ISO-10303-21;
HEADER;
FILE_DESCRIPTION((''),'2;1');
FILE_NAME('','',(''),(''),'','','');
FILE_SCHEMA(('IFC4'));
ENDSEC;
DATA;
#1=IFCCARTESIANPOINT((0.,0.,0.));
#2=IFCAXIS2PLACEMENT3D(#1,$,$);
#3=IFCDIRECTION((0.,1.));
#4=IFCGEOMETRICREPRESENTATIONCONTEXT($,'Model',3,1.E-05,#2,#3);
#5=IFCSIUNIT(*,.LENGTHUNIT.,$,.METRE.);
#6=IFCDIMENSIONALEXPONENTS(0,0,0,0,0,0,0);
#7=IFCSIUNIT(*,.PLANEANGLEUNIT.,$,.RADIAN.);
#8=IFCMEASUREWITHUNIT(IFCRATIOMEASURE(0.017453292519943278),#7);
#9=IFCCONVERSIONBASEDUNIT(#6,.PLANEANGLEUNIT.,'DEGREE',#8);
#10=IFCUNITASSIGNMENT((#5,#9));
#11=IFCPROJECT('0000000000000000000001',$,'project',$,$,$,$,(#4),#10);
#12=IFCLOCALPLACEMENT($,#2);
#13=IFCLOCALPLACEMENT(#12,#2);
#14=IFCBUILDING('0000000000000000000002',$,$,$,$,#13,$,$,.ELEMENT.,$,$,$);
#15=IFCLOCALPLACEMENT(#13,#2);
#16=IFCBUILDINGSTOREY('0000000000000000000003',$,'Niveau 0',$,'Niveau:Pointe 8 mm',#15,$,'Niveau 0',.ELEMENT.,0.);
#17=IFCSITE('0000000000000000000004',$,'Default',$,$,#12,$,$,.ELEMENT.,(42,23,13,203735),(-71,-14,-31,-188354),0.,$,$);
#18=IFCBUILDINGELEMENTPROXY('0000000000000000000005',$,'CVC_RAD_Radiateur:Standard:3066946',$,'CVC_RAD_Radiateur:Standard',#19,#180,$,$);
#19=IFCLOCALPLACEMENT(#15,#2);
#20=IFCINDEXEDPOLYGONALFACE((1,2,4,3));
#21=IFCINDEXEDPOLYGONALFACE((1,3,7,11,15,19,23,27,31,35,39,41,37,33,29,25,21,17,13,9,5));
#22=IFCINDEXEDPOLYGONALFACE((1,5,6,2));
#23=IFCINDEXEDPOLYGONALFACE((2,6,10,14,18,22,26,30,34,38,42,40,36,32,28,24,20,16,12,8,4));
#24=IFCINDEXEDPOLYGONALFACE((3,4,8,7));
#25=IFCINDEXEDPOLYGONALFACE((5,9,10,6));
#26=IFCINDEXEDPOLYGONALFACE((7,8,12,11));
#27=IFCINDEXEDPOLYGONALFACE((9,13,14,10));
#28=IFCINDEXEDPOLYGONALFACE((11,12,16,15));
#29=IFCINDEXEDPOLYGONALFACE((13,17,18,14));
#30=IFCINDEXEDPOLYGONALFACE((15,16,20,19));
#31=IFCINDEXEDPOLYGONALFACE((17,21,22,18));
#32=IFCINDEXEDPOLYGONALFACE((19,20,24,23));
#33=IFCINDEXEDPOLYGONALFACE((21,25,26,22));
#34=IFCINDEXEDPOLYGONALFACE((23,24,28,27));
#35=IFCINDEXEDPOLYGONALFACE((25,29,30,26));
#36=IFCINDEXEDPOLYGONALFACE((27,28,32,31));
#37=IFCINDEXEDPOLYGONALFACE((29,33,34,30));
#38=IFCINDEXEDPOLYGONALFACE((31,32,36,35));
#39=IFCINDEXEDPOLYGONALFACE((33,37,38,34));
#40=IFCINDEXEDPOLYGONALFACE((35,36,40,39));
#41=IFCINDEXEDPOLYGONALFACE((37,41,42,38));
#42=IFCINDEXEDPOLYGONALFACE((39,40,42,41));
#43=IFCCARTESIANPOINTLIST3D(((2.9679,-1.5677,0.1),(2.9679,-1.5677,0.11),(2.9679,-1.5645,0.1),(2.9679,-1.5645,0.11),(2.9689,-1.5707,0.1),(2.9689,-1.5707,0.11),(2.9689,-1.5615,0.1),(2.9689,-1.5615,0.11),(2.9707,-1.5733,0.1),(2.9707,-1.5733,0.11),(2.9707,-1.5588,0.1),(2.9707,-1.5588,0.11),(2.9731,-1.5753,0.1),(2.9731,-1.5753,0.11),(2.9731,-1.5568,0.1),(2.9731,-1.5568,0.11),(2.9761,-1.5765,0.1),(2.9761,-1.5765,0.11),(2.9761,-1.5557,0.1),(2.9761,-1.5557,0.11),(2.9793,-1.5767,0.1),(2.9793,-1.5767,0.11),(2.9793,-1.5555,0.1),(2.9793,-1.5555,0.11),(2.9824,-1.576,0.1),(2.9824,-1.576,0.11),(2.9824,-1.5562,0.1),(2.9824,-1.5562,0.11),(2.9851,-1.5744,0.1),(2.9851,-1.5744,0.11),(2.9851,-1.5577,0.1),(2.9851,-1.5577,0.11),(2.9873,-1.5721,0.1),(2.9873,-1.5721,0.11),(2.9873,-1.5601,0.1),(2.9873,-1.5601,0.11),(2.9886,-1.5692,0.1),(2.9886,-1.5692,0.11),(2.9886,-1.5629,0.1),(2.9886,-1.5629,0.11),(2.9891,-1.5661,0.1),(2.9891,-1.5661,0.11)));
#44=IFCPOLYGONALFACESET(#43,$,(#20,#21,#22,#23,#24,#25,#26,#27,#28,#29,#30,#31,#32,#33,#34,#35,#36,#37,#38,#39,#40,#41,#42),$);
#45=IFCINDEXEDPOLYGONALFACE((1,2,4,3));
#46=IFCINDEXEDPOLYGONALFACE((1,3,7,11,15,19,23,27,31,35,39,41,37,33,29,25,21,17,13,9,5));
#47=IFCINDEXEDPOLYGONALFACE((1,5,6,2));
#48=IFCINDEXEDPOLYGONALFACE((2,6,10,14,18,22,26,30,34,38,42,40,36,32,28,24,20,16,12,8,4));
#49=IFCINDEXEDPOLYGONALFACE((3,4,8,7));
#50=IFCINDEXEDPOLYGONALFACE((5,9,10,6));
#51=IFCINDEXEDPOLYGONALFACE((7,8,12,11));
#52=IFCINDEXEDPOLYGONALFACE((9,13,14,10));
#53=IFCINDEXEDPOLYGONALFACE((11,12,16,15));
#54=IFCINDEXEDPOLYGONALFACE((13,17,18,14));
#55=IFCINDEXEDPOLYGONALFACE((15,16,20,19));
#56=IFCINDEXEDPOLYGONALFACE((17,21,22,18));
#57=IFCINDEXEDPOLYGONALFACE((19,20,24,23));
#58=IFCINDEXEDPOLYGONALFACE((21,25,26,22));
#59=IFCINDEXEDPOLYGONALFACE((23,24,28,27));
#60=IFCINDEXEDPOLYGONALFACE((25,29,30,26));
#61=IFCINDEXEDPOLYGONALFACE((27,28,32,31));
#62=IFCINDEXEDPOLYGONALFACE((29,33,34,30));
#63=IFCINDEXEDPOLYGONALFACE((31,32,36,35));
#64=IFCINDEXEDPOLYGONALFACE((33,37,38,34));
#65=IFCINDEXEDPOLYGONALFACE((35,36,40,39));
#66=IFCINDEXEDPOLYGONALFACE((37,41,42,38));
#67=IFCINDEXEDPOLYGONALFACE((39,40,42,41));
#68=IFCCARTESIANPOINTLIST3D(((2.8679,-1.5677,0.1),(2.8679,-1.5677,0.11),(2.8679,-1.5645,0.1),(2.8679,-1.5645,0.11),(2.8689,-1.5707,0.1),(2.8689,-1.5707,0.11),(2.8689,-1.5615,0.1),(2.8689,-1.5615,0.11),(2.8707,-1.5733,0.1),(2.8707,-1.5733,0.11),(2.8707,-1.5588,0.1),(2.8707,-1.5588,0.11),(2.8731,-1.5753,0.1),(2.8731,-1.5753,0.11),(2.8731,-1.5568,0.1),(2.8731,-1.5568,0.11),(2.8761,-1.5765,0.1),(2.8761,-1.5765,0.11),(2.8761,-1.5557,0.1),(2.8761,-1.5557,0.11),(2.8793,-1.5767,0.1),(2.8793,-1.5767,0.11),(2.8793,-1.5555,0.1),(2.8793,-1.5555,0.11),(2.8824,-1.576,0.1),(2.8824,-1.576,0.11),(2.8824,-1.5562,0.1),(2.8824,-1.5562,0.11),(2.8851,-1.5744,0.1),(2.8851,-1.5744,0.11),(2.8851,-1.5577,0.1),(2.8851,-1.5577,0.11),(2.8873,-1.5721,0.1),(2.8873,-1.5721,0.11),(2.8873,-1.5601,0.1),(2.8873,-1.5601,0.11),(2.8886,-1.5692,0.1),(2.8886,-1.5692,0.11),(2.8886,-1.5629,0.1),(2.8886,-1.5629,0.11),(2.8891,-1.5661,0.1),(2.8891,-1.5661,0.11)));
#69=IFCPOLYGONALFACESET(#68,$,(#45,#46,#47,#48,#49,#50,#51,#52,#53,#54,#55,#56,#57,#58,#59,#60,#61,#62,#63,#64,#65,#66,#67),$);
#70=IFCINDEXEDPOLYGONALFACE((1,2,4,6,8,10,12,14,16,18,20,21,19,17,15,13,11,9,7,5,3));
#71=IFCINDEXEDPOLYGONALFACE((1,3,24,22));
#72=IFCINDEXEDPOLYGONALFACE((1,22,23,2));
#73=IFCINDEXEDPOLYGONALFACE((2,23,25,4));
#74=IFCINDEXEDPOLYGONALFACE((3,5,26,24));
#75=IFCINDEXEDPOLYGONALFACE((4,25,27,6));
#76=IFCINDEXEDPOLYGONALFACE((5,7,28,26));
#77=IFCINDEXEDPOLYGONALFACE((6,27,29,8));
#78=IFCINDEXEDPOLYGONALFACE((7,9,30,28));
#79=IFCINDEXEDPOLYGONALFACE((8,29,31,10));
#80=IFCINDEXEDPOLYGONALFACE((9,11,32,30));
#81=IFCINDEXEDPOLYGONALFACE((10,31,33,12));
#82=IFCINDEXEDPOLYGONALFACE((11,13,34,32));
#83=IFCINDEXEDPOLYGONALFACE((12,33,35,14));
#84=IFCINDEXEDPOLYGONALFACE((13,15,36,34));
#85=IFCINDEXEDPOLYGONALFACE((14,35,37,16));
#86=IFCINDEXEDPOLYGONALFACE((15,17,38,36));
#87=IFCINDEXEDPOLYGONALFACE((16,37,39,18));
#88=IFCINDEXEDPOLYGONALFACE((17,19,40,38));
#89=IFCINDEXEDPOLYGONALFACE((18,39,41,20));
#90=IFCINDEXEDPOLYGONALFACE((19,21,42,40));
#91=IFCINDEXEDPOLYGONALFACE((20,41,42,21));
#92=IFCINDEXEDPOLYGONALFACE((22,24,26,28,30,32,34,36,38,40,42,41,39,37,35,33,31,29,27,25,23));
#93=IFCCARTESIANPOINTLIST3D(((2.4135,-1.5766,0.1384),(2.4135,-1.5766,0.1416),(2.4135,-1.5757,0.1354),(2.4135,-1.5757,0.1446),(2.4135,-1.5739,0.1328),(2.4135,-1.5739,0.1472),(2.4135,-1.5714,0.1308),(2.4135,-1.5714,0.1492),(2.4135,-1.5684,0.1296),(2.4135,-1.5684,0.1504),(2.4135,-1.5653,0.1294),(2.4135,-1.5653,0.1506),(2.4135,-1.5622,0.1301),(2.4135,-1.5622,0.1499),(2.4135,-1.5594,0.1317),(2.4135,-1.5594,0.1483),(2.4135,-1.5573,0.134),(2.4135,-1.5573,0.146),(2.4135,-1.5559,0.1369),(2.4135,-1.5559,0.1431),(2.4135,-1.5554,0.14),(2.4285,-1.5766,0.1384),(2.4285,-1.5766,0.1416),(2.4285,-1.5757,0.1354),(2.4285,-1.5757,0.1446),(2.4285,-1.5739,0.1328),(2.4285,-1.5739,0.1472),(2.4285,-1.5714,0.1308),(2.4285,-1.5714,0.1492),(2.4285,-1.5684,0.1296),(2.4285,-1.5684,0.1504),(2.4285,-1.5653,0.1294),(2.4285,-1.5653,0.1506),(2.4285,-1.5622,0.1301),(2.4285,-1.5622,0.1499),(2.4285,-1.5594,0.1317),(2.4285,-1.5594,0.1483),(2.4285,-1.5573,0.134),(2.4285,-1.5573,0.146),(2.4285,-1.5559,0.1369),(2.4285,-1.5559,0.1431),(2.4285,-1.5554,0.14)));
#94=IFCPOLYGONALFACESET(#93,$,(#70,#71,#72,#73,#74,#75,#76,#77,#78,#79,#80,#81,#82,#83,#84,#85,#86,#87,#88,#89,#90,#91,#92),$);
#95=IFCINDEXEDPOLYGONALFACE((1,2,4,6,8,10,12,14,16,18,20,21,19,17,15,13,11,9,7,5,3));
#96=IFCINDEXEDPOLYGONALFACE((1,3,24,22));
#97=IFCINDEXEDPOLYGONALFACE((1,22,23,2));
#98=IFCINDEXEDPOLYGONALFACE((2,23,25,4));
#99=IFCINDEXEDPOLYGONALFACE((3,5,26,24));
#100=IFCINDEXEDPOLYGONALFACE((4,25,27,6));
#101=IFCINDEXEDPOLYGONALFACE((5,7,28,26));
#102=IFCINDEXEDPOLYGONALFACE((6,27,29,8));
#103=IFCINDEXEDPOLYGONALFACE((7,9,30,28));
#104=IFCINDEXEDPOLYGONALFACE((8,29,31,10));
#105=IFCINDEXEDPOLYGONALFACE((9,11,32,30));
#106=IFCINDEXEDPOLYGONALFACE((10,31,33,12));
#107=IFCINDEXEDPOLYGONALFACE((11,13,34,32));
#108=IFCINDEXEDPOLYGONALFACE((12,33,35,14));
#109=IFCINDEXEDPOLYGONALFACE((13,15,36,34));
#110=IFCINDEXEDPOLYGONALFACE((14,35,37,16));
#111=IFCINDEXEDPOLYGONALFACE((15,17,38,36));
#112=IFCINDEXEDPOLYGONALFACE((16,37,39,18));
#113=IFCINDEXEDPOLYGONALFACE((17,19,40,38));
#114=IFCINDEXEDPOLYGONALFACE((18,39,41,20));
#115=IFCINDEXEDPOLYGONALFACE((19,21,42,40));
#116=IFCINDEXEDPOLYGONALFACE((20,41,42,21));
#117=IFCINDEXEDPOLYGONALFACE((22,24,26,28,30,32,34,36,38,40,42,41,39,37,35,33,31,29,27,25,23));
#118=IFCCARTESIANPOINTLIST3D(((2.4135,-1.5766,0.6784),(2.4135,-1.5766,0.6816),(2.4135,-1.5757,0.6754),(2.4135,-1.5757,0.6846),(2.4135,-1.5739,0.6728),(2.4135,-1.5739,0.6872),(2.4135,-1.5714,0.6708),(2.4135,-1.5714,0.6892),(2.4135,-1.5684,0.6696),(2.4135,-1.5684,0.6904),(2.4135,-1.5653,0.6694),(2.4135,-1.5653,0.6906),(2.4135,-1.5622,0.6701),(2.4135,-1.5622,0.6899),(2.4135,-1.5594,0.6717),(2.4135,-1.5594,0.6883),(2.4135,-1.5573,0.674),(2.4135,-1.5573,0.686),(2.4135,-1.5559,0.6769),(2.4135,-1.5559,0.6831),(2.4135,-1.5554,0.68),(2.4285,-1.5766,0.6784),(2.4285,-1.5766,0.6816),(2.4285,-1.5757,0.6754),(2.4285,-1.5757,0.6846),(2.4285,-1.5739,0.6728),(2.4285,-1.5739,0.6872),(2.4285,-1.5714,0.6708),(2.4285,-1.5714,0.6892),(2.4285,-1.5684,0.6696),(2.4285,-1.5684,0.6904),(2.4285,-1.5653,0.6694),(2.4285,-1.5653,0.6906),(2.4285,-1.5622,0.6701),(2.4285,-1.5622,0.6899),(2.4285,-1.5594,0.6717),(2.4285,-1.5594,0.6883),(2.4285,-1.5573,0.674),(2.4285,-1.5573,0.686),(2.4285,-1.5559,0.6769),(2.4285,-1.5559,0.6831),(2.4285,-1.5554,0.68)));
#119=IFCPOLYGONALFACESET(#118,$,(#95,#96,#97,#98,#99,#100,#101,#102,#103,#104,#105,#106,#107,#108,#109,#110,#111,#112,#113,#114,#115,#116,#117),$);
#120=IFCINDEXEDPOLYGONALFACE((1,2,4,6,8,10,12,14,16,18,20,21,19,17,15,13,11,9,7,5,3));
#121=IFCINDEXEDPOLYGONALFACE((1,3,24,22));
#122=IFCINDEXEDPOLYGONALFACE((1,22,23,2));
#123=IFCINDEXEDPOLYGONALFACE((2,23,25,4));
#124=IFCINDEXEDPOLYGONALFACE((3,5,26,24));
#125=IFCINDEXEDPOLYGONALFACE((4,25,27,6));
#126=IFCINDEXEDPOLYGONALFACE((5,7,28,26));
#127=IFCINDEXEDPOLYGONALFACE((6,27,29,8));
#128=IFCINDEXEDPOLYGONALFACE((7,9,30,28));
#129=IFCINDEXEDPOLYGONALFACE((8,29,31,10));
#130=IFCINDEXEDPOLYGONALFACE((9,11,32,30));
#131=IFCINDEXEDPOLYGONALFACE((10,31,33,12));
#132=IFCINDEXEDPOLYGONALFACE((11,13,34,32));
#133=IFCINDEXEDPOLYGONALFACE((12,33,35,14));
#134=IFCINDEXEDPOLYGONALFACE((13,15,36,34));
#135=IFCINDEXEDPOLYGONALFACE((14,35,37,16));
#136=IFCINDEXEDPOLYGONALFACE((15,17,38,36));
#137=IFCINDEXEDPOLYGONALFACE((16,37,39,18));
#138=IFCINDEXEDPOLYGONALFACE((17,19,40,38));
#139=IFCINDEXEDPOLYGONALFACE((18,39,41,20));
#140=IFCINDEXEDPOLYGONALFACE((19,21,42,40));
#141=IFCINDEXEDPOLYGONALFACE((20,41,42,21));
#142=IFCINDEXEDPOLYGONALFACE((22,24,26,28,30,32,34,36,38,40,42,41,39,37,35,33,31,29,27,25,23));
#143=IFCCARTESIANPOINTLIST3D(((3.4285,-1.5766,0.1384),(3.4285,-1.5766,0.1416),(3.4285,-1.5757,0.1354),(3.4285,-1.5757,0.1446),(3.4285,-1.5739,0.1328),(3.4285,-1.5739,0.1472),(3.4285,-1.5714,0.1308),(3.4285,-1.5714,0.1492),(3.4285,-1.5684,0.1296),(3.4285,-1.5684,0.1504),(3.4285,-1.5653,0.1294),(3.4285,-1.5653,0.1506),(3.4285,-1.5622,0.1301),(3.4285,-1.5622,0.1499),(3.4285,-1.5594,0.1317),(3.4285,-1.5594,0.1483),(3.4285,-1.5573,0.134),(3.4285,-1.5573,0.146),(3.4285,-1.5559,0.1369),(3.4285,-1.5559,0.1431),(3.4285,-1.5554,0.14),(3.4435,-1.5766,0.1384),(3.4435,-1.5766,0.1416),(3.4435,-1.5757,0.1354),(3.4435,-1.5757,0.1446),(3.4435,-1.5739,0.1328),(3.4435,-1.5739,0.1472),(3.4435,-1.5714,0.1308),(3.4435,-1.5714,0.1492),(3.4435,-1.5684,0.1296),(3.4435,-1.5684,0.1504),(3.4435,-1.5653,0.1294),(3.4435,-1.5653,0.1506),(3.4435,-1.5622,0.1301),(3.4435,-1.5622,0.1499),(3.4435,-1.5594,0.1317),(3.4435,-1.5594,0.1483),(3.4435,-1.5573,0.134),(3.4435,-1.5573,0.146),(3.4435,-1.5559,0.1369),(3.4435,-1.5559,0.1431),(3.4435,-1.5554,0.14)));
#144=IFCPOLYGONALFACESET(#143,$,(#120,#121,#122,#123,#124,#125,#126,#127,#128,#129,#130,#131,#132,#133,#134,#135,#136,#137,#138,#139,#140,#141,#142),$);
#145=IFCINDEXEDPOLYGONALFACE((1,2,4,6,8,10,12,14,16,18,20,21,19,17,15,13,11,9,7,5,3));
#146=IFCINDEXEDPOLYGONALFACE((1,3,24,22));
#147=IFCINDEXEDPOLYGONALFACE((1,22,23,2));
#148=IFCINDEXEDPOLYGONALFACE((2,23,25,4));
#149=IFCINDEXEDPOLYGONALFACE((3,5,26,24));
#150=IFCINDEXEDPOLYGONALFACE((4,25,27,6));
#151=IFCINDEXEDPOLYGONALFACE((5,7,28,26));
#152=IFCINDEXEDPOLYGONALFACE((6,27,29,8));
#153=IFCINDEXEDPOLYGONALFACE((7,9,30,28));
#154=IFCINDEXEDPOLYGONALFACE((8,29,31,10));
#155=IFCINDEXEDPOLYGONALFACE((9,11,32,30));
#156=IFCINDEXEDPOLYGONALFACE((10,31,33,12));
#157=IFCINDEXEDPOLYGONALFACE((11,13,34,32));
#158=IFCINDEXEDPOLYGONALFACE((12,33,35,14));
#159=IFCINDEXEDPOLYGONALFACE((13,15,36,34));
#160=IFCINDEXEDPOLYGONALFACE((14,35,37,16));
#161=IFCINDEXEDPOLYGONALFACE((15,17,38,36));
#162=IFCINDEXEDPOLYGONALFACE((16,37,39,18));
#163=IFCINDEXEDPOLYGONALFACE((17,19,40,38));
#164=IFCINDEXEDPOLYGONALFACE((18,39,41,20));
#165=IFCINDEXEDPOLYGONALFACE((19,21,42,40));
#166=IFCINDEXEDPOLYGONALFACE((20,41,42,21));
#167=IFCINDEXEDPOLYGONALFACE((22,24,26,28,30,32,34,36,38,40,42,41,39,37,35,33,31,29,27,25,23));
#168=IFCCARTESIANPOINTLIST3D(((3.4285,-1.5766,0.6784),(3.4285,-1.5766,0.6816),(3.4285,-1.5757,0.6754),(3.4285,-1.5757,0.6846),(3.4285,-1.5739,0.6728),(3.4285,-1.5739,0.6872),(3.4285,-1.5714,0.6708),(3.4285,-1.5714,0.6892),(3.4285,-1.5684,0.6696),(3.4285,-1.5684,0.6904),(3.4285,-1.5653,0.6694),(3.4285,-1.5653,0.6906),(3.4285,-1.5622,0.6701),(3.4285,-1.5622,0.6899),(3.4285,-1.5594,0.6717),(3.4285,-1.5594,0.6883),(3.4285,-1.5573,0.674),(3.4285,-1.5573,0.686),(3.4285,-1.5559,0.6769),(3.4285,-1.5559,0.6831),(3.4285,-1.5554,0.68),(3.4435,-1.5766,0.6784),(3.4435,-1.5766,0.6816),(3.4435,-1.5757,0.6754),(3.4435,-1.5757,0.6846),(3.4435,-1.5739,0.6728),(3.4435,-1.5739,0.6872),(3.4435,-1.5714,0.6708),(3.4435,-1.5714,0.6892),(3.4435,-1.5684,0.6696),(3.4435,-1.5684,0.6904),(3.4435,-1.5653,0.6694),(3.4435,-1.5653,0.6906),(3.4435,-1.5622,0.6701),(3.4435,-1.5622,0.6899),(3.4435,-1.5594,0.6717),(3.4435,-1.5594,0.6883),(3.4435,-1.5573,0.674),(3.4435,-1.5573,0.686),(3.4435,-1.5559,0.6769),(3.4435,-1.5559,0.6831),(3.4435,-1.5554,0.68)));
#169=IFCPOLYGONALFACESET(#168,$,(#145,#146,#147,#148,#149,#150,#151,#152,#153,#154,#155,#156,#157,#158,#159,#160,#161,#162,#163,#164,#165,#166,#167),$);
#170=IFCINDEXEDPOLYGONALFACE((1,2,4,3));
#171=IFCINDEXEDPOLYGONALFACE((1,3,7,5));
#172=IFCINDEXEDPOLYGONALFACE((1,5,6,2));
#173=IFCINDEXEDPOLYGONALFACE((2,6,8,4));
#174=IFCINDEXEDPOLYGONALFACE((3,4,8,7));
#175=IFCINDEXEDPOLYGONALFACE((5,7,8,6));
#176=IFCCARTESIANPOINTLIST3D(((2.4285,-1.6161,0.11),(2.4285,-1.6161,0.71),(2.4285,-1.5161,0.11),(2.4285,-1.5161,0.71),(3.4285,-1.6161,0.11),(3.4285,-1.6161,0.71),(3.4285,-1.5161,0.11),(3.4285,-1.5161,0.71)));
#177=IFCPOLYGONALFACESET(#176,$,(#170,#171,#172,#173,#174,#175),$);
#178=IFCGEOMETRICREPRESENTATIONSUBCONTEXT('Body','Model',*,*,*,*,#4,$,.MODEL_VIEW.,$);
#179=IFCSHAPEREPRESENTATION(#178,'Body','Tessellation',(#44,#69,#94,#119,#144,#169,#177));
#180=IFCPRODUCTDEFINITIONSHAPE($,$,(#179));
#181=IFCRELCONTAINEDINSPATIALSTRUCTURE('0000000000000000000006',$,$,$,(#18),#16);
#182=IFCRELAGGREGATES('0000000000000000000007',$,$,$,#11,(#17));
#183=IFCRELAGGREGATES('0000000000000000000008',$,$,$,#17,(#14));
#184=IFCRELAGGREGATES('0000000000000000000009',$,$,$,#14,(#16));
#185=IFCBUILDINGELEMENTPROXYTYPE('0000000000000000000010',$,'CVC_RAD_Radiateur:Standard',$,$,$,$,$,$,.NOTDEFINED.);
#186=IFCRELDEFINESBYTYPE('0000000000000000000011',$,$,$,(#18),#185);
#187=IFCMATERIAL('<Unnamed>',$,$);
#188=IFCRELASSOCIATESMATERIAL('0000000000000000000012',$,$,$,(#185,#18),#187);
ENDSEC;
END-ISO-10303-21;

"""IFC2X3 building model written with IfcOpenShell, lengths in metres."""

from ifc_helpers import new_model, entity, si_unit, converted_unit, direction, frame, frame_2d, origin, origin_2d_with_axis, place, context, subcontext, project, spatial, rectangle, circle, extrude, source, transform, mapped, material, type_object, type_shapes, element, save


model = new_model("IFC2X3")

# Units and contexts
model_context = context("Model", 3, precision=1e-05, world=origin(), true_north=direction((0.0, 1.0)))
body_context = subcontext(model_context, "Body", "Model", "MODEL_VIEW")
ifc_project = project(units=[si_unit("LENGTHUNIT", "METRE"), converted_unit("PLANEANGLEUNIT", "DEGREE", entity("IfcRatioMeasure", 0.017453292519943278), si_unit("PLANEANGLEUNIT", "RADIAN"), dimensions=[0, 0, 0, 0, 0, 0, 0])], contexts=[model_context])

# Site, building, storey
site_placement = place(None, origin())
site = spatial("IfcSite", under=ifc_project, at=site_placement, Name="Default", CompositionType="ELEMENT", RefLatitude=(42, 23, 13, 203735), RefLongitude=(-71, -14, -31, -188354), RefElevation=0.0)
building_placement = place(site_placement, origin())
building = spatial("IfcBuilding", under=site, at=building_placement, CompositionType="ELEMENT")
storey_placement = place(building_placement, origin())
storey = spatial("IfcBuildingStorey", under=building, at=storey_placement, Name="Niveau 0", ObjectType="Niveau:Pointe 8 mm", LongName="Niveau 0", CompositionType="ELEMENT", Elevation=0.0)

# Building element proxy
ifc_material = material(Name="<Unnamed>")
building_element_proxy_type = type_object("IfcBuildingElementProxyType", Name="CVC_RAD_Radiateur:Standard", PredefinedType="NOTDEFINED", material=ifc_material)
shared_shape = source(origin(), body_context, "Body", "SweptSolid", [
    extrude(circle(Radius=0.0107, at=frame_2d((0.0, 0.0), x_axis=(1.0, 0.0))), frame((0.05, 0.055, 0.0)), (0.0, 0.0, 1.0), 0.01),
    extrude(circle(Radius=0.0107, at=frame_2d((0.0, 0.0), x_axis=(1.0, 0.0))), frame((-0.05, 0.055, 0.0)), (0.0, 0.0, 1.0), 0.01),
    extrude(circle(Radius=0.0107, at=frame_2d((0.0, 0.0), x_axis=(1.0, 0.0))), frame((-0.515, 0.055, 0.04), z_axis=(1.0, 0.0, 0.0), x_axis=(0.0, 1.0, 0.0)), (0.0, 0.0, 1.0), 0.015),
    extrude(circle(Radius=0.0107, at=frame_2d((0.0, 0.0), x_axis=(1.0, 0.0))), frame((-0.515, 0.055, 0.58), z_axis=(1.0, 0.0, 0.0), x_axis=(0.0, 1.0, 0.0)), (0.0, 0.0, 1.0), 0.015),
    extrude(circle(Radius=0.0107, at=frame_2d((0.0, 0.0), x_axis=(1.0, 0.0))), frame((0.5, 0.055, 0.04), z_axis=(1.0, 0.0, 0.0), x_axis=(0.0, 1.0, 0.0)), (0.0, 0.0, 1.0), 0.015),
    extrude(circle(Radius=0.0107, at=origin_2d_with_axis()), frame((0.5, 0.055, 0.58), z_axis=(1.0, 0.0, 0.0), x_axis=(0.0, 1.0, 0.0)), (0.0, 0.0, 1.0), 0.015),
    extrude(rectangle(XDim=1.0, YDim=0.1, at=origin_2d_with_axis()), frame((0.0, 0.055, 0.01), z_axis=(0.0, 0.0, 1.0), x_axis=(-1.0, 0.0, 0.0)), (0.0, 0.0, 1.0), 0.6),
])
type_shapes(building_element_proxy_type, [shared_shape])
for number, where, name in (
    (1, (2.9285, -1.6211, 0.1), "CVC_RAD_Radiateur:Standard:3066946"),
):
    element("IfcBuildingElementProxy", number, at=place(storey_placement, frame(where)), inside=storey, type_object=building_element_proxy_type, material=ifc_material, Name=name, ObjectType="CVC_RAD_Radiateur:Standard", context=body_context, shape_type="MappedRepresentation", body=[
        mapped(shared_shape, transform((0.0, 0.0, 0.0), scale=1.0)),
    ])

save(model, "model.ifc")
